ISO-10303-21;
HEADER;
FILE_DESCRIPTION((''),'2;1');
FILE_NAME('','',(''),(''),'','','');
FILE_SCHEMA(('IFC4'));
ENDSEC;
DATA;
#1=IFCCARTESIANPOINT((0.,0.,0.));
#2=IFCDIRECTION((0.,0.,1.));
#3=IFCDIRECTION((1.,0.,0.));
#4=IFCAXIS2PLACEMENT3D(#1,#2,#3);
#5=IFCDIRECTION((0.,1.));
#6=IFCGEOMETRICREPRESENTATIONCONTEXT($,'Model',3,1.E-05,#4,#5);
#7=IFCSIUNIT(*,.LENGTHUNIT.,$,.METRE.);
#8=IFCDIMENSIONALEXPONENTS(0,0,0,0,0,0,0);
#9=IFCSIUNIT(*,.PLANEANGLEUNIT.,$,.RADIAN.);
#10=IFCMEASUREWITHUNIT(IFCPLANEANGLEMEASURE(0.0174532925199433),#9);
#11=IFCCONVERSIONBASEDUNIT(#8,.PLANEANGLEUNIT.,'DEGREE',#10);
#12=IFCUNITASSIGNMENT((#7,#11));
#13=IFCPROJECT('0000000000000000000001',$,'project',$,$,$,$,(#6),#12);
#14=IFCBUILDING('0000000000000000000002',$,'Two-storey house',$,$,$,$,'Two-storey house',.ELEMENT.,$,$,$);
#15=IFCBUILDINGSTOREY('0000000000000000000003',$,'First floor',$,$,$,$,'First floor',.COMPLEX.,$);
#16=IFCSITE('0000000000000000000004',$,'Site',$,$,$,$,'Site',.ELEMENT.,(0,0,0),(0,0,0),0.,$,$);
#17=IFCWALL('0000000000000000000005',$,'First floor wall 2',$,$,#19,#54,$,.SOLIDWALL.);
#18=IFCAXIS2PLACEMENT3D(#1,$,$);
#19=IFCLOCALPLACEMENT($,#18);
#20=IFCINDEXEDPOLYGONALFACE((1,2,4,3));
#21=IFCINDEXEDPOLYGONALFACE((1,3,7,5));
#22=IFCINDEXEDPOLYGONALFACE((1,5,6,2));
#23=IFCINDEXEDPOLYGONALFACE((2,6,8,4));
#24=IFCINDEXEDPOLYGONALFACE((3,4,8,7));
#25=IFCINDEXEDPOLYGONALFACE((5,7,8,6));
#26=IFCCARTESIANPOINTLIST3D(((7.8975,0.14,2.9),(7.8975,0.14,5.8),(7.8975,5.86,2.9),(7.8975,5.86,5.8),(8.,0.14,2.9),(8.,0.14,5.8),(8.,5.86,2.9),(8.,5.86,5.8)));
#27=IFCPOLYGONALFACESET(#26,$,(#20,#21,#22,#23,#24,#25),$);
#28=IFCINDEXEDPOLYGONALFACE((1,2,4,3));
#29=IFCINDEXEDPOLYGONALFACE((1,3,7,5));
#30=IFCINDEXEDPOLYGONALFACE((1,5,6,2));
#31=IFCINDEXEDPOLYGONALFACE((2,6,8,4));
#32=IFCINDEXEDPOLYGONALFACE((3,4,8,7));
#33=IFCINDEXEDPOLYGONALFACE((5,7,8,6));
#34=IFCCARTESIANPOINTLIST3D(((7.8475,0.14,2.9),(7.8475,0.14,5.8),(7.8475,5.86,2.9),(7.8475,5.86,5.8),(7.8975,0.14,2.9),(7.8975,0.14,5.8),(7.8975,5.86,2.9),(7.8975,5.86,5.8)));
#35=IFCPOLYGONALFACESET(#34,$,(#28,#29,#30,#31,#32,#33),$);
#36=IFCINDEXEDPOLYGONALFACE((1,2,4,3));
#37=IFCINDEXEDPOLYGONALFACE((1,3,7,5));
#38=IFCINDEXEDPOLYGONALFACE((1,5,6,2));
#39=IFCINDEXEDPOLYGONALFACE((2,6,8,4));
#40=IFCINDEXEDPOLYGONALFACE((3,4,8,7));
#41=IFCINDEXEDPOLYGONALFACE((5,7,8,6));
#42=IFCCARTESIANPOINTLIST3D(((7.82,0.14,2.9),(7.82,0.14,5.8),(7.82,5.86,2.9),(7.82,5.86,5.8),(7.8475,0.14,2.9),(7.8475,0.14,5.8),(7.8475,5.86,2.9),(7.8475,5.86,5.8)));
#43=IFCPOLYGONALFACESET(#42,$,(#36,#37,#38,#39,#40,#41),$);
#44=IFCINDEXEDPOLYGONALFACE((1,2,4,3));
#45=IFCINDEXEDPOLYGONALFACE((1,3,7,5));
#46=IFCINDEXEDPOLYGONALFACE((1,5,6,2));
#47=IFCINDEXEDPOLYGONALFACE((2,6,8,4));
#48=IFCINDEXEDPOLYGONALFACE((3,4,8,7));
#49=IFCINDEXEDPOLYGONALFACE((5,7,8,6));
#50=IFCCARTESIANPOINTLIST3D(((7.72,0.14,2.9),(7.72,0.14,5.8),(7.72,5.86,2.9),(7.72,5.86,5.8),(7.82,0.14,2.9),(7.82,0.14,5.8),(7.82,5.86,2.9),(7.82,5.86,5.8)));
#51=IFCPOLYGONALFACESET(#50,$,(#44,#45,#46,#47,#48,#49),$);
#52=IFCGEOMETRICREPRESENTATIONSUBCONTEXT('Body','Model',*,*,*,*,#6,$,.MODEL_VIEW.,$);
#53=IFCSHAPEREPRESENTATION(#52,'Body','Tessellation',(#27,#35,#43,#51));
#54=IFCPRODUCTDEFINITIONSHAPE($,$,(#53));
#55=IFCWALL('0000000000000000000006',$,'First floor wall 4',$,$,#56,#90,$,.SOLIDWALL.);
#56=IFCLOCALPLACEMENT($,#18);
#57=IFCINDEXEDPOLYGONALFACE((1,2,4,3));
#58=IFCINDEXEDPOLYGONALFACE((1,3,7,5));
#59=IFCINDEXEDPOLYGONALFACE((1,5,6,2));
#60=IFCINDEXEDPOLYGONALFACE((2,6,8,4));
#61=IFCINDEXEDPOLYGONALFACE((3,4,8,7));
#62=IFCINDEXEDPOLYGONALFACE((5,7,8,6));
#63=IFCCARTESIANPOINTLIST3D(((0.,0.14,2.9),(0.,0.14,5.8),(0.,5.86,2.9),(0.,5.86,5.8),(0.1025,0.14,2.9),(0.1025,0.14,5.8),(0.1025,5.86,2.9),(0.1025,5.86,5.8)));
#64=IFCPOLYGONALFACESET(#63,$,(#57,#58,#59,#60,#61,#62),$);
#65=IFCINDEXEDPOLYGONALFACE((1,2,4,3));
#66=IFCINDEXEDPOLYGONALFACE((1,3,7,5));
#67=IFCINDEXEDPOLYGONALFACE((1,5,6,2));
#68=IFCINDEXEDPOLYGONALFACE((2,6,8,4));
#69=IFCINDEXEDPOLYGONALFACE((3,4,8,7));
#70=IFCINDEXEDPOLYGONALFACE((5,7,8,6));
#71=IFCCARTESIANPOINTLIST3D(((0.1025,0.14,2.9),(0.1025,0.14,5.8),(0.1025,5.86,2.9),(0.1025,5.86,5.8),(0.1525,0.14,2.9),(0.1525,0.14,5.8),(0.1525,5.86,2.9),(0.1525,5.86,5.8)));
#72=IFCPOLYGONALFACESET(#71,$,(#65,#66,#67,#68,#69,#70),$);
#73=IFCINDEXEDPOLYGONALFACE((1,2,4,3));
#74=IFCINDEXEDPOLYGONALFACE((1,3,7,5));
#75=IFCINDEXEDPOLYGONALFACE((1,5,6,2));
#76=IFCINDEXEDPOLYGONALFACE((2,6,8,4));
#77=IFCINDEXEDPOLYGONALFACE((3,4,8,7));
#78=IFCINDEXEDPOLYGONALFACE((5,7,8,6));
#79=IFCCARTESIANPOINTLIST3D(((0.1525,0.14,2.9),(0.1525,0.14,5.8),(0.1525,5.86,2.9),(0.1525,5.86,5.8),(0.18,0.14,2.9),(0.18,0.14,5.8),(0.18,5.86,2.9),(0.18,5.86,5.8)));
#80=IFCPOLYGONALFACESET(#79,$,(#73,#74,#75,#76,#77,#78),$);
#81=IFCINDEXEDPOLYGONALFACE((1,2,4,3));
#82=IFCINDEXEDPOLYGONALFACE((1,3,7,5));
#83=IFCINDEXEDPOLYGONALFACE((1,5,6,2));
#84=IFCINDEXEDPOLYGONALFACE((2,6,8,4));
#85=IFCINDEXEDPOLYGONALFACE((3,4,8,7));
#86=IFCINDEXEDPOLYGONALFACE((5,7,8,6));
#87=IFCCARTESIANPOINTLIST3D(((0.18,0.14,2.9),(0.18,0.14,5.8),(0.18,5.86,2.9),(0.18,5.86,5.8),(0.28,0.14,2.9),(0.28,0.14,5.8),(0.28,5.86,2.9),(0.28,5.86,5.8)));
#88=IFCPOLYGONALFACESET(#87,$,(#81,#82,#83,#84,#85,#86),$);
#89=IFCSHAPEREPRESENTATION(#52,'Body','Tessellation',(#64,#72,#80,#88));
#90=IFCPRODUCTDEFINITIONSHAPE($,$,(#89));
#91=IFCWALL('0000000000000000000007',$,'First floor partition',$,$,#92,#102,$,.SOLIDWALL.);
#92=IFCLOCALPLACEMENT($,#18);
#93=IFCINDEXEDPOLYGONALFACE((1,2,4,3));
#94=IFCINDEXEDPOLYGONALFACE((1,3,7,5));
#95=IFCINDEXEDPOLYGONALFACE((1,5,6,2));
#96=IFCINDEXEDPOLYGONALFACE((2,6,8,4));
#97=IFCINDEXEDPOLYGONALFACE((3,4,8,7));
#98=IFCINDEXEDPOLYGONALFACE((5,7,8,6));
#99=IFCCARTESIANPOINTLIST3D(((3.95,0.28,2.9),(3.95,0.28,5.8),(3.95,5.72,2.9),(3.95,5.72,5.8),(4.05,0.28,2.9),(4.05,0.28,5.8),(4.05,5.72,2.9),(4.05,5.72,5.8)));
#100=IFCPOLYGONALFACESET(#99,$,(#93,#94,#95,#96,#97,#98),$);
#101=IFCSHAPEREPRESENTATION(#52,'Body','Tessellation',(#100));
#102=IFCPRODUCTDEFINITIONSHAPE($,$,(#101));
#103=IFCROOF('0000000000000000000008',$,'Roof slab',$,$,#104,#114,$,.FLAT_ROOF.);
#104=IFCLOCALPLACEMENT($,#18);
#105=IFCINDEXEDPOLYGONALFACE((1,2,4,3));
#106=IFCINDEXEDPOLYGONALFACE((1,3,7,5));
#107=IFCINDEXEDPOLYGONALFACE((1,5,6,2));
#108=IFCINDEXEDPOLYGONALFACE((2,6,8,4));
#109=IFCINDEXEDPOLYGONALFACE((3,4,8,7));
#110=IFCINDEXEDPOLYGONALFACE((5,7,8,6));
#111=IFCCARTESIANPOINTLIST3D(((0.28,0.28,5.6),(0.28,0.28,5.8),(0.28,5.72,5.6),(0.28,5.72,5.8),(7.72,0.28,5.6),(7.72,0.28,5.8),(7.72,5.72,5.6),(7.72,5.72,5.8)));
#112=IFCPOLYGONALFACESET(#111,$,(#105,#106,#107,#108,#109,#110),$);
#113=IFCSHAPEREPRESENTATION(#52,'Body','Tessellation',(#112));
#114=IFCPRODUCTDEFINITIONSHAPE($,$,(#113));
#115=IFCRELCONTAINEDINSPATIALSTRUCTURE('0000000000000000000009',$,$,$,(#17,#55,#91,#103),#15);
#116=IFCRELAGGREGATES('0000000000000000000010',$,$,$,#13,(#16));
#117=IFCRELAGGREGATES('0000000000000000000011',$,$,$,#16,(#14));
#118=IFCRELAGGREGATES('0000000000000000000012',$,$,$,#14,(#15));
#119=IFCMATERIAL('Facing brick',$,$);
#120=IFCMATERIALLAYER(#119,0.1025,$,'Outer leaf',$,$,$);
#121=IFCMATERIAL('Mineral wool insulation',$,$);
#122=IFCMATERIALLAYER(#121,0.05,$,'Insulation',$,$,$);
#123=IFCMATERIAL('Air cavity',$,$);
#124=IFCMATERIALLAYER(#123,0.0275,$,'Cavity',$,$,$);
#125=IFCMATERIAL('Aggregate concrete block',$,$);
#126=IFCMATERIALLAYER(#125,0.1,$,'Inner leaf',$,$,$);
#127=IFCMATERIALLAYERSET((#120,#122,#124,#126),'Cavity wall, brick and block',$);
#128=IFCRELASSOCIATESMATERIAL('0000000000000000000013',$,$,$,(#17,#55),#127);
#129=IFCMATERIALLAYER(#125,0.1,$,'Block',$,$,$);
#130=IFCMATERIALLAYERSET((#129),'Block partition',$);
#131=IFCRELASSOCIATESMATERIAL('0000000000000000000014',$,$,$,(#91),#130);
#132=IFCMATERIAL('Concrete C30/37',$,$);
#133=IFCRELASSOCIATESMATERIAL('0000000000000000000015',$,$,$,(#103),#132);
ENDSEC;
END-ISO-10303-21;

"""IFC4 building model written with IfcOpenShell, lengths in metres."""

from ifc_helpers import new_model, entity, si_unit, converted_unit, direction, frame, frame_2d, origin_with_axes, origin_2d_with_axis, place, context, subcontext, project, spatial, rectangle, extrude, material, layer, layer_set, layer_usage, element, save


model = new_model("IFC4")

# Units and contexts
model_context = context("Model", 3, precision=1e-05, world=origin_with_axes(), true_north=direction((0.0, 1.0)))
body_context = subcontext(model_context, "Body", "Model", "MODEL_VIEW")
ifc_project = project(units=[si_unit("LENGTHUNIT", "METRE"), converted_unit("PLANEANGLEUNIT", "DEGREE", entity("IfcPlaneAngleMeasure", 0.0174532925199433), si_unit("PLANEANGLEUNIT", "RADIAN"), dimensions=[0, 0, 0, 0, 0, 0, 0])], contexts=[model_context])

# Site, building, storey
site = spatial("IfcSite", under=ifc_project, Name="Site", LongName="Site", CompositionType="ELEMENT", RefLatitude=(0, 0, 0), RefLongitude=(0, 0, 0), RefElevation=0.0)
building = spatial("IfcBuilding", under=site, Name="Two-storey house", LongName="Two-storey house", CompositionType="ELEMENT")
storey = spatial("IfcBuildingStorey", under=building, Name="First floor", LongName="First floor", CompositionType="COMPLEX")

# Walls
ifc_material_1 = material(Name="Facing brick")
ifc_layer_1 = layer(ifc_material_1, 0.1025, Name="Outer leaf")
ifc_material_2 = material(Name="Mineral wool insulation")
ifc_layer_2 = layer(ifc_material_2, 0.05, Name="Insulation")
ifc_material_3 = material(Name="Air cavity")
ifc_layer_3 = layer(ifc_material_3, 0.0275, Name="Cavity")
ifc_material_4 = material(Name="Aggregate concrete block")
ifc_layer_4 = layer(ifc_material_4, 0.1, Name="Inner leaf")
ifc_layer_set_1 = layer_set([ifc_layer_1, ifc_layer_2, ifc_layer_3, ifc_layer_4], Name="Cavity wall, brick and block")
ifc_layer_usage_1 = layer_usage(ifc_layer_set_1, "AXIS2", "POSITIVE", -0.14)
placement = place(None, origin_with_axes())
element("IfcWall", 1, at=placement, inside=storey, material=ifc_layer_usage_1, Name="First floor wall 2", PredefinedType="SOLIDWALL", context=body_context, shape_type="SweptSolid", body=[
    extrude(rectangle(XDim=5.72, YDim=0.1025, at=frame_2d((0.0, 0.0), x_axis=(0.0, 1.0))), frame((7.9488, 3.0, 2.9), z_axis=(0.0, 0.0, 1.0), x_axis=(1.0, 0.0, 0.0)), (0.0, 0.0, 1.0), 2.9),
    extrude(rectangle(XDim=5.72, YDim=0.05, at=frame_2d((-0.0763, 0.0), x_axis=(0.0, 1.0))), frame((7.9488, 3.0, 2.9), z_axis=(0.0, 0.0, 1.0), x_axis=(1.0, 0.0, 0.0)), (0.0, 0.0, 1.0), 2.9),
    extrude(rectangle(XDim=5.72, YDim=0.0275, at=frame_2d((-0.115, 0.0), x_axis=(0.0, 1.0))), frame((7.9488, 3.0, 2.9), z_axis=(0.0, 0.0, 1.0), x_axis=(1.0, 0.0, 0.0)), (0.0, 0.0, 1.0), 2.9),
    extrude(rectangle(XDim=5.72, YDim=0.1, at=frame_2d((-0.1787, 0.0), x_axis=(0.0, 1.0))), frame((7.9488, 3.0, 2.9), z_axis=(0.0, 0.0, 1.0), x_axis=(1.0, 0.0, 0.0)), (0.0, 0.0, 1.0), 2.9),
])
ifc_layer_usage_2 = layer_usage(ifc_layer_set_1, "AXIS2", "POSITIVE", -0.14)
element("IfcWall", 2, at=placement, inside=storey, material=ifc_layer_usage_2, Name="First floor wall 4", PredefinedType="SOLIDWALL", context=body_context, shape_type="SweptSolid", body=[
    extrude(rectangle(XDim=5.72, YDim=0.1025, at=frame_2d((0.0, 0.0), x_axis=(0.0, 1.0))), frame((0.0512, 3.0, 2.9), z_axis=(0.0, 0.0, 1.0), x_axis=(1.0, 0.0, 0.0)), (0.0, 0.0, 1.0), 2.9),
    extrude(rectangle(XDim=5.72, YDim=0.05, at=frame_2d((0.0763, 0.0), x_axis=(0.0, 1.0))), frame((0.0512, 3.0, 2.9), z_axis=(0.0, 0.0, 1.0), x_axis=(1.0, 0.0, 0.0)), (0.0, 0.0, 1.0), 2.9),
    extrude(rectangle(XDim=5.72, YDim=0.0275, at=frame_2d((0.115, 0.0), x_axis=(0.0, 1.0))), frame((0.0512, 3.0, 2.9), z_axis=(0.0, 0.0, 1.0), x_axis=(1.0, 0.0, 0.0)), (0.0, 0.0, 1.0), 2.9),
    extrude(rectangle(XDim=5.72, YDim=0.1, at=frame_2d((0.1788, 0.0), x_axis=(0.0, 1.0))), frame((0.0512, 3.0, 2.9), z_axis=(0.0, 0.0, 1.0), x_axis=(1.0, 0.0, 0.0)), (0.0, 0.0, 1.0), 2.9),
])
ifc_layer_5 = layer(ifc_material_4, 0.1, Name="Block")
ifc_layer_set_2 = layer_set([ifc_layer_5], Name="Block partition")
ifc_layer_usage_3 = layer_usage(ifc_layer_set_2, "AXIS2", "POSITIVE", -0.05)
element("IfcWall", 3, at=placement, inside=storey, material=ifc_layer_usage_3, Name="First floor partition", PredefinedType="SOLIDWALL", context=body_context, shape_type="SweptSolid", body=[
    extrude(rectangle(XDim=5.44, YDim=0.1, at=frame_2d((0.0, 0.0), x_axis=(0.0, 1.0))), frame((4.0, 3.0, 2.9), z_axis=(0.0, 0.0, 1.0), x_axis=(1.0, 0.0, 0.0)), (0.0, 0.0, 1.0), 2.9),
])

# Roof
ifc_material_5 = material(Name="Concrete C30/37")
element("IfcRoof", 4, at=placement, inside=storey, material=ifc_material_5, Name="Roof slab", PredefinedType="FLAT_ROOF", context=body_context, shape_type="SweptSolid", body=[
    extrude(rectangle(XDim=7.44, YDim=5.44, at=origin_2d_with_axis()), frame((4.0, 3.0, 5.6), z_axis=(0.0, 0.0, 1.0), x_axis=(1.0, 0.0, 0.0)), (0.0, 0.0, 1.0), 0.2),
])

save(model, "model.ifc")
